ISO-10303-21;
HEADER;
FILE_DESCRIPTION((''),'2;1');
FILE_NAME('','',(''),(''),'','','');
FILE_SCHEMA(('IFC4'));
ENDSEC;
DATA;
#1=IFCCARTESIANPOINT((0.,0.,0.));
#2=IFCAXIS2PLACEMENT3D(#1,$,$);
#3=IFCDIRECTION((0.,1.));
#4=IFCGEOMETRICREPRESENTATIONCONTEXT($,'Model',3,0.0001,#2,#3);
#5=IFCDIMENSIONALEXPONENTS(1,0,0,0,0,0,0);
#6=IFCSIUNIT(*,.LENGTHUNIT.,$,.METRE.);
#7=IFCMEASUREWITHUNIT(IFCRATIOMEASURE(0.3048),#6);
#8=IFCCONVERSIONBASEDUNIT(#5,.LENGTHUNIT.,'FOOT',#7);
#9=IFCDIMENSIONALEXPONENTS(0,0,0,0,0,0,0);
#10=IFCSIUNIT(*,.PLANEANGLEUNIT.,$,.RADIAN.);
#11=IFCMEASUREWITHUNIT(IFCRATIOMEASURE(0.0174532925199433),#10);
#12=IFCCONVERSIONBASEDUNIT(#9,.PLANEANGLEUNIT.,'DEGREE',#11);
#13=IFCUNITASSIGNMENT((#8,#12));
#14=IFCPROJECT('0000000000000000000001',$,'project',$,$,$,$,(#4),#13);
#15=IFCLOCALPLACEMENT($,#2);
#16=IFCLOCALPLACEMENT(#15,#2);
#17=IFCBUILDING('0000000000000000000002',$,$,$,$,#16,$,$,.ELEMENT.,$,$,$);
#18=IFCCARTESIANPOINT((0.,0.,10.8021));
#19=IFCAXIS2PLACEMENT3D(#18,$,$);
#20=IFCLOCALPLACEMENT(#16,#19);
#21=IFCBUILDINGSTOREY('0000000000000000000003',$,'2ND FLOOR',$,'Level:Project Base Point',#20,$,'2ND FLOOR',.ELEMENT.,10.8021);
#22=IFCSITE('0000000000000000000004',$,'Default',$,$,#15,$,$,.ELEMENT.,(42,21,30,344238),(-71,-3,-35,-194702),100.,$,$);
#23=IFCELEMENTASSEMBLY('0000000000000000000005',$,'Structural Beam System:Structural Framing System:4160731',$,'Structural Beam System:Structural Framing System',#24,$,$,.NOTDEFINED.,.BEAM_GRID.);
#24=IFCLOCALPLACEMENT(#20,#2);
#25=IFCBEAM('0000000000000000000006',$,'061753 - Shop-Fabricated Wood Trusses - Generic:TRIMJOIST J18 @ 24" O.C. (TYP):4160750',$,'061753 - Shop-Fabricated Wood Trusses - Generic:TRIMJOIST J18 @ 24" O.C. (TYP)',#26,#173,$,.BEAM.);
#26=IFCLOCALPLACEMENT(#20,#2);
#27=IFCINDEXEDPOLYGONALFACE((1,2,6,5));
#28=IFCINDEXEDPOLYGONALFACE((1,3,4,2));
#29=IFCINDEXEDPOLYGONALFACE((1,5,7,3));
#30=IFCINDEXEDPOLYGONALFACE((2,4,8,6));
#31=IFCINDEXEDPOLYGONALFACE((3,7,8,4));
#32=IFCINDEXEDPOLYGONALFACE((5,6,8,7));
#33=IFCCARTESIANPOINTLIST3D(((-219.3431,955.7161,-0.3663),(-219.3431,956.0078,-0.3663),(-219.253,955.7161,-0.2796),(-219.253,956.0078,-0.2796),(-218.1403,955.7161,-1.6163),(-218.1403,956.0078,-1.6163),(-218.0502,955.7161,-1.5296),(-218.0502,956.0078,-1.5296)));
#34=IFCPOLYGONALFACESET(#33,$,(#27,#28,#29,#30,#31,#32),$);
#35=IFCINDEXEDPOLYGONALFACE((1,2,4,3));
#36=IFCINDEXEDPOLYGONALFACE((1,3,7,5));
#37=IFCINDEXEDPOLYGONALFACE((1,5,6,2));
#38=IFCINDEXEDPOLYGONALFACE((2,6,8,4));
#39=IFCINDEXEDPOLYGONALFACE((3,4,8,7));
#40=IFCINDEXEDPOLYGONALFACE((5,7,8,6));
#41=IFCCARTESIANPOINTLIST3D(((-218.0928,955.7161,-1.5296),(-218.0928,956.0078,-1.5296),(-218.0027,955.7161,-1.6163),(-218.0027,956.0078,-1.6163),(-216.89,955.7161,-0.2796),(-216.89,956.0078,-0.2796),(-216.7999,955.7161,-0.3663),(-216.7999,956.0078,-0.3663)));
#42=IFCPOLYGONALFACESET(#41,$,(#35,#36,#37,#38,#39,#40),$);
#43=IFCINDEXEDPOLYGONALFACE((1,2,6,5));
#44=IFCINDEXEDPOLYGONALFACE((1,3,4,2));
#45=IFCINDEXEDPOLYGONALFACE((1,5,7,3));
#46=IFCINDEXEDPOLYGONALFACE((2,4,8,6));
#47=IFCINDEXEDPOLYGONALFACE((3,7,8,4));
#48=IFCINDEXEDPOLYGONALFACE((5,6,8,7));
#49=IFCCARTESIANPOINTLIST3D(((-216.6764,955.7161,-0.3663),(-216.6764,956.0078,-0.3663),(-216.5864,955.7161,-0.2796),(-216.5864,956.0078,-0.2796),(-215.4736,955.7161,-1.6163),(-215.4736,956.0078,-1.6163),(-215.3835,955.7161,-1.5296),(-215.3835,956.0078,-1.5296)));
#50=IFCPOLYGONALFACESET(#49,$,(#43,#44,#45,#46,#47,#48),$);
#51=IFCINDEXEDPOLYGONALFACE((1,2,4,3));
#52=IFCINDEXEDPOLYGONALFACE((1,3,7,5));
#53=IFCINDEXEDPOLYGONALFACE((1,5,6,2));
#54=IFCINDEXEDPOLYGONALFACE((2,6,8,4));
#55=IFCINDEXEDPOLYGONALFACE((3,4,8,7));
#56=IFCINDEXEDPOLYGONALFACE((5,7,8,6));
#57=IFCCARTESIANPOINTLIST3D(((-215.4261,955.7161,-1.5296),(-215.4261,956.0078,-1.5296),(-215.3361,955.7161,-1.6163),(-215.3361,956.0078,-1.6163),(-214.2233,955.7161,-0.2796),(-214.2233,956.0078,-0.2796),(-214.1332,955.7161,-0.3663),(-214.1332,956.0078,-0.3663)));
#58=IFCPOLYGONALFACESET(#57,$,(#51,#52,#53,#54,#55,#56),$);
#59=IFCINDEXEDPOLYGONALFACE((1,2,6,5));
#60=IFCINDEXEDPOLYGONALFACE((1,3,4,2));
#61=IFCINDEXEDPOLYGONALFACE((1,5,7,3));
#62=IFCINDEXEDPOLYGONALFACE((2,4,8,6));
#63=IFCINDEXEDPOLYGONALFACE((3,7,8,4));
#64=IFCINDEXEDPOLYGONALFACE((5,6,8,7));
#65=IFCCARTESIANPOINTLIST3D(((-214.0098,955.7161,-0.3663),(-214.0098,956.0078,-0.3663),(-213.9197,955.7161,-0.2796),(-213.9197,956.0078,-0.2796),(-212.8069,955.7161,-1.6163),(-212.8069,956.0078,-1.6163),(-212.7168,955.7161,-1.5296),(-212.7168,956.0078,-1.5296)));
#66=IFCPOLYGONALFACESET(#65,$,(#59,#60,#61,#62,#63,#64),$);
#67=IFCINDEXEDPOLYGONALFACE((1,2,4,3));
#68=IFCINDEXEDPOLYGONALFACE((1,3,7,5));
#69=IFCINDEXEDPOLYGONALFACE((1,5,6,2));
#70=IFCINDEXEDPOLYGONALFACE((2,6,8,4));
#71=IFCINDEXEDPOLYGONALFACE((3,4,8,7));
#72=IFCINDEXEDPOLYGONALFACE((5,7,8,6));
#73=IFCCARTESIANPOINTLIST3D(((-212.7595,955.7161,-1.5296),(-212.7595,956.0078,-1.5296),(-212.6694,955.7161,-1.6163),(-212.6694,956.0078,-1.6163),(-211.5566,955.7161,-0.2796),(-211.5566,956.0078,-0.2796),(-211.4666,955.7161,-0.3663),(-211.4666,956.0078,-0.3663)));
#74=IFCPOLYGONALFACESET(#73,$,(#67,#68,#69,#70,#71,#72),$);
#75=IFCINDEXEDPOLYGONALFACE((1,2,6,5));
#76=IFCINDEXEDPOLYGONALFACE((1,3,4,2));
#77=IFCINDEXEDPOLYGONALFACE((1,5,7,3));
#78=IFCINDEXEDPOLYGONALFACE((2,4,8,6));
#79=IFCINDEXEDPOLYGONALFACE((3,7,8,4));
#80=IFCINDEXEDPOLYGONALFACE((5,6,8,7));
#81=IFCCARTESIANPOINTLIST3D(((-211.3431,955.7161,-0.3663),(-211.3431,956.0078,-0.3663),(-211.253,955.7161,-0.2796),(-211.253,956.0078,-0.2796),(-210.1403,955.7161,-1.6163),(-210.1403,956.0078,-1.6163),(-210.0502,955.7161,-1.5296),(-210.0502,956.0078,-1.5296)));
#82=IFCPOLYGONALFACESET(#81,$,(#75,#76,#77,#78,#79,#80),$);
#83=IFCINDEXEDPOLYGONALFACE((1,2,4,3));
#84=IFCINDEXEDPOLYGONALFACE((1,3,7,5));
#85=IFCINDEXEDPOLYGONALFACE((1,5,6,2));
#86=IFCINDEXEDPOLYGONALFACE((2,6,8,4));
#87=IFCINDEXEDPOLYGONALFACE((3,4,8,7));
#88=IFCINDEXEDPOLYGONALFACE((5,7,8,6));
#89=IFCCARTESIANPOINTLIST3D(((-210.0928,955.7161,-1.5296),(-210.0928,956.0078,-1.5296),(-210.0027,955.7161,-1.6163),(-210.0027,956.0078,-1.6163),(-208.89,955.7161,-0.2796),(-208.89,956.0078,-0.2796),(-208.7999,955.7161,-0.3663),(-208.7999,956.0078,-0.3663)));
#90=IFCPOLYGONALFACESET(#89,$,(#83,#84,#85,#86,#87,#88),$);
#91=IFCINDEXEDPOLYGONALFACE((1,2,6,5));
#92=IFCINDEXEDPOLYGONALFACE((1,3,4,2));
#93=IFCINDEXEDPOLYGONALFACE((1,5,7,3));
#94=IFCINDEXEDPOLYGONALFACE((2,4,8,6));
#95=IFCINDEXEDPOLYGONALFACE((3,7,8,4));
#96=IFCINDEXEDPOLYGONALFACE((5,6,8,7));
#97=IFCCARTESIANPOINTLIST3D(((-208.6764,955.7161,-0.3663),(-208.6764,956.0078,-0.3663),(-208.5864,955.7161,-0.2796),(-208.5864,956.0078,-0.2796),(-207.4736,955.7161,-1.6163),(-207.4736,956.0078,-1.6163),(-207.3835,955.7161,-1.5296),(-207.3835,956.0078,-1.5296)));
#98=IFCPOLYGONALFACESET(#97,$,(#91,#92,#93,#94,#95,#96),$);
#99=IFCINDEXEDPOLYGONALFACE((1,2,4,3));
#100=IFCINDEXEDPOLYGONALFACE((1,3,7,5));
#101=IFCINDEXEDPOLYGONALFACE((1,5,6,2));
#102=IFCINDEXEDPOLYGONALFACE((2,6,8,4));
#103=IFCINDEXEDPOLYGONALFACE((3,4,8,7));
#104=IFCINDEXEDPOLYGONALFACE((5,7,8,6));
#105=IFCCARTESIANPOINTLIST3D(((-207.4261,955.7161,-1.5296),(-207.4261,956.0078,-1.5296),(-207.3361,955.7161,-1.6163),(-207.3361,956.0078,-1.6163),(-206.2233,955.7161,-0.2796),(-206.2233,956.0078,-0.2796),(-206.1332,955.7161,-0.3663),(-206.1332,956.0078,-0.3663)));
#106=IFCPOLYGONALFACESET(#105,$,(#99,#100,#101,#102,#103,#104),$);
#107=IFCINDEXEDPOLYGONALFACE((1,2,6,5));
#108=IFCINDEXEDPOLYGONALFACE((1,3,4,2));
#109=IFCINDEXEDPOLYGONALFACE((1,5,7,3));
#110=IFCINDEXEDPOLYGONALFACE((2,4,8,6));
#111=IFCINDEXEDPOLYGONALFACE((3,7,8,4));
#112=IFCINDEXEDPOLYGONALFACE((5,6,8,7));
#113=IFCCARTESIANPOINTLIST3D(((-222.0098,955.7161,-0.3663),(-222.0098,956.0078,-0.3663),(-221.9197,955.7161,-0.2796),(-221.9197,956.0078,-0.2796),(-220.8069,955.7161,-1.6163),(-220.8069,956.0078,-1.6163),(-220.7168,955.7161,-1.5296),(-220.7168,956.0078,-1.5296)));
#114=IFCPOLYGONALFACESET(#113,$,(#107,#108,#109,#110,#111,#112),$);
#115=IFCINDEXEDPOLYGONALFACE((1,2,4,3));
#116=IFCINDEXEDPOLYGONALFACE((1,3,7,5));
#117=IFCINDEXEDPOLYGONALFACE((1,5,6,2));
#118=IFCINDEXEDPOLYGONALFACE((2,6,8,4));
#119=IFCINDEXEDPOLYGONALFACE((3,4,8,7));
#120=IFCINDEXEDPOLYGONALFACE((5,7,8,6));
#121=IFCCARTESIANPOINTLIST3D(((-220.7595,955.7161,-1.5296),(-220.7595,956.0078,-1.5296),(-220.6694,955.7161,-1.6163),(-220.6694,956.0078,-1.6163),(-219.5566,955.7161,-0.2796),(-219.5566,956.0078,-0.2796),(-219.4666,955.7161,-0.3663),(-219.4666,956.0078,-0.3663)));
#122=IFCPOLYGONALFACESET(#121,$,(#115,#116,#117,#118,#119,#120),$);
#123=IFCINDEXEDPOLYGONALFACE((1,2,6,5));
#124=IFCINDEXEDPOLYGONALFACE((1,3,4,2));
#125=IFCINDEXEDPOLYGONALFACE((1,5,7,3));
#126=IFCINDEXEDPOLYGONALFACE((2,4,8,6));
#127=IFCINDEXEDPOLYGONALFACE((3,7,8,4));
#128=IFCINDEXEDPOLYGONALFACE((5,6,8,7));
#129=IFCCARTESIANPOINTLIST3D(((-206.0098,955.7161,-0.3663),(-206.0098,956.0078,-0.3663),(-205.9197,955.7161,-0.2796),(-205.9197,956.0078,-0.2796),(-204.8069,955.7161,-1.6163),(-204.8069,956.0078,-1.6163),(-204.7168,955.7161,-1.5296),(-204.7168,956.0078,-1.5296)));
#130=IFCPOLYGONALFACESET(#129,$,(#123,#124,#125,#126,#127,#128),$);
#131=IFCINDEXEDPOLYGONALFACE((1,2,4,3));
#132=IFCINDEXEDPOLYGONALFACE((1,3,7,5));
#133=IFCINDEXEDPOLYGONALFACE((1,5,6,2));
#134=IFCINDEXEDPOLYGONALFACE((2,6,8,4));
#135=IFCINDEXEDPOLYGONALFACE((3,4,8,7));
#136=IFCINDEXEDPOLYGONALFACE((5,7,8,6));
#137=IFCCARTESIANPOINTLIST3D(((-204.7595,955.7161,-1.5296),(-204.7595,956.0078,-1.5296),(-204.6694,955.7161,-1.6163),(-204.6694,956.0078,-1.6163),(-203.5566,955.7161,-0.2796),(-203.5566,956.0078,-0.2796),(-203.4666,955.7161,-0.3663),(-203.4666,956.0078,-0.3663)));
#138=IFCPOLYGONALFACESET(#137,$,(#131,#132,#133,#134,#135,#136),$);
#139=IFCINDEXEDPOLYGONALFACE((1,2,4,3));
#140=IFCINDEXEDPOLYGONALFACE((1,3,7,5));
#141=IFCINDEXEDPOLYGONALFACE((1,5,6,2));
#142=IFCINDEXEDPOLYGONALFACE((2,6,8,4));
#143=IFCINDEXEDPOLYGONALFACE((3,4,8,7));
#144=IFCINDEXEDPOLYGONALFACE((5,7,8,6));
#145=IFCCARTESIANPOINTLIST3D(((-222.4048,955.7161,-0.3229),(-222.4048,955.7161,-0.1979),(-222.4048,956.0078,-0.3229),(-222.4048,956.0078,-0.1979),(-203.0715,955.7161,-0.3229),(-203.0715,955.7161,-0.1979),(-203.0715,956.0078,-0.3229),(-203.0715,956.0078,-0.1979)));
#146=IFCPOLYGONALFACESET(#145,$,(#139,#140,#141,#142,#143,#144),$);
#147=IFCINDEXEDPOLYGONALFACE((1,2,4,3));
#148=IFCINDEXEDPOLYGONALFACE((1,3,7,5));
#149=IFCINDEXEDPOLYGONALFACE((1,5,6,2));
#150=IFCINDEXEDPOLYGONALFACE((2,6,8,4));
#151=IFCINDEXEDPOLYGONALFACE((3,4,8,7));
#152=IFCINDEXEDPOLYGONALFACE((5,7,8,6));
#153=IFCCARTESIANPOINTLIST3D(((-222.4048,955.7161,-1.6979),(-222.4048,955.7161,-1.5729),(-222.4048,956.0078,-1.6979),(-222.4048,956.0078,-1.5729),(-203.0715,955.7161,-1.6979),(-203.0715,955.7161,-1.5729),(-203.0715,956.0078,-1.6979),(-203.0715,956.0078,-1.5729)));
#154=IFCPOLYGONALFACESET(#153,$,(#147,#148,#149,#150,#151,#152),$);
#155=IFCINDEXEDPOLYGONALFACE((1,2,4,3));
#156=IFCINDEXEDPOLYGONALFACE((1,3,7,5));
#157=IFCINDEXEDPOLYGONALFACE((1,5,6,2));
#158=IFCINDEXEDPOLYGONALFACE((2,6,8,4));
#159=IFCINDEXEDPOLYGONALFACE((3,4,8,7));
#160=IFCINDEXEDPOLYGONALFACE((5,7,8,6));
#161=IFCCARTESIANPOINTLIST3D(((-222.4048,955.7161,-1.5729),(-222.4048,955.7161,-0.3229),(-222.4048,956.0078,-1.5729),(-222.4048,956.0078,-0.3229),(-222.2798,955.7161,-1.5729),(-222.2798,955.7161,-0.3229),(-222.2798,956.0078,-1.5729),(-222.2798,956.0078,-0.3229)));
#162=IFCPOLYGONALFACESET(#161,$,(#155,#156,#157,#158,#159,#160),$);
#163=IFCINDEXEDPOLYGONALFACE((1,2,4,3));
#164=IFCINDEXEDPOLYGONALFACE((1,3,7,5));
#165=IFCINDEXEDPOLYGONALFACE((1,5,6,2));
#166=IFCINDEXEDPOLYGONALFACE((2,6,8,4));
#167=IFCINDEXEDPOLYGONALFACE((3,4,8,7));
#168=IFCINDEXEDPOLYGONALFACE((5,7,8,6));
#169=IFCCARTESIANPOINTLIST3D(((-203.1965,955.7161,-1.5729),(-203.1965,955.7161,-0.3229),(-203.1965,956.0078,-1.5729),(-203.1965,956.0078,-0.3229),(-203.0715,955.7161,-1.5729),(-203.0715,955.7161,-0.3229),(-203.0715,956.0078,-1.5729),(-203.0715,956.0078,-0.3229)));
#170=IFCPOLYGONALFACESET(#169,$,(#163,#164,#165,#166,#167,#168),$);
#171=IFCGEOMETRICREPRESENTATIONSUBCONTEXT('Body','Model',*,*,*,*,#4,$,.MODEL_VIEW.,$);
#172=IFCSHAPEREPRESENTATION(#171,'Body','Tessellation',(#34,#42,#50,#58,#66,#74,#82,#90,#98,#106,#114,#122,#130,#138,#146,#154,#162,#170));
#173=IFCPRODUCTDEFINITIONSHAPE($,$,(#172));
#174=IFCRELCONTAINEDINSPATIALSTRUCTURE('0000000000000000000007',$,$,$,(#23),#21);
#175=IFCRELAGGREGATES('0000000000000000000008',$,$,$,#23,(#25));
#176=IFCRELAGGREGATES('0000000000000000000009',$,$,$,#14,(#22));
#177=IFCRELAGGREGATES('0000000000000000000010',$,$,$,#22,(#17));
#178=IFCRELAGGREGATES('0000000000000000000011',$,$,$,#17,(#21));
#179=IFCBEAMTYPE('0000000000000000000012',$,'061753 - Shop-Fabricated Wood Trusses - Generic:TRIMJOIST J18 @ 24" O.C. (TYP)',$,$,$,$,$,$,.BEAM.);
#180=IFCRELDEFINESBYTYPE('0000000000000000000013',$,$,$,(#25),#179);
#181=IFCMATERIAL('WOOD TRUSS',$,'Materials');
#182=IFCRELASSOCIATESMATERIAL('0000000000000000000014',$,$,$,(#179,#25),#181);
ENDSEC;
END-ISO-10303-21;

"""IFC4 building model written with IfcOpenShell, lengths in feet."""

from ifc_helpers import new_model, entity, si_unit, converted_unit, direction, frame, frame_2d, origin, origin_2d_with_axis, place, context, subcontext, project, spatial, rectangle, extrude, source, transform, mapped, material, material_profile, profile_set, profile_usage, type_object, type_shapes, element, aggregate, save


model = new_model("IFC4")

# Units and contexts
model_context = context("Model", 3, precision=0.0001, world=origin(), true_north=direction((0.0, 1.0)))
body_context = subcontext(model_context, "Body", "Model", "MODEL_VIEW")
ifc_project = project(units=[converted_unit("LENGTHUNIT", "FOOT", entity("IfcRatioMeasure", 0.3048), si_unit("LENGTHUNIT", "METRE"), dimensions=[1, 0, 0, 0, 0, 0, 0]), converted_unit("PLANEANGLEUNIT", "DEGREE", entity("IfcRatioMeasure", 0.0174532925199433), si_unit("PLANEANGLEUNIT", "RADIAN"), dimensions=[0, 0, 0, 0, 0, 0, 0])], contexts=[model_context])

# Site, building, storey
site_placement = place(None, origin())
site = spatial("IfcSite", under=ifc_project, at=site_placement, Name="Default", CompositionType="ELEMENT", RefLatitude=(42, 21, 30, 344238), RefLongitude=(-71, -3, -35, -194702), RefElevation=100.0)
building_placement = place(site_placement, origin())
building = spatial("IfcBuilding", under=site, at=building_placement, CompositionType="ELEMENT")
storey_placement = place(building_placement, frame((0.0, 0.0, 10.8021)))
storey = spatial("IfcBuildingStorey", under=building, at=storey_placement, Name="2ND FLOOR", ObjectType="Level:Project Base Point", LongName="2ND FLOOR", CompositionType="ELEMENT", Elevation=10.8021)

# Shared definitions
ifc_material_1 = material(Name="WOOD TRUSS", Category="Materials")
ifc_material_profile_1 = material_profile(ifc_material_1, rectangle(XDim=1.7347, YDim=0.125, at=frame_2d((0.0, 0.0), x_axis=(1.0, 0.0))), Name="TRIMJOIST J18 @ 24\" O.C. (TYP)")
ifc_material_profile_2 = material_profile(ifc_material_1, rectangle(XDim=1.7347, YDim=0.125, at=frame_2d((0.0, 0.0), x_axis=(1.0, 0.0))), Name="TRIMJOIST J18 @ 24\" O.C. (TYP)")
ifc_material_profile_3 = material_profile(ifc_material_1, rectangle(XDim=1.7347, YDim=0.125, at=frame_2d((0.0, 0.0), x_axis=(1.0, 0.0))), Name="TRIMJOIST J18 @ 24\" O.C. (TYP)")
ifc_material_profile_4 = material_profile(ifc_material_1, rectangle(XDim=1.7347, YDim=0.125, at=frame_2d((0.0, 0.0), x_axis=(1.0, 0.0))), Name="TRIMJOIST J18 @ 24\" O.C. (TYP)")
ifc_material_profile_5 = material_profile(ifc_material_1, rectangle(XDim=1.7347, YDim=0.125, at=frame_2d((0.0, 0.0), x_axis=(1.0, 0.0))), Name="TRIMJOIST J18 @ 24\" O.C. (TYP)")
ifc_material_profile_6 = material_profile(ifc_material_1, rectangle(XDim=1.7347, YDim=0.125, at=frame_2d((0.0, 0.0), x_axis=(1.0, 0.0))), Name="TRIMJOIST J18 @ 24\" O.C. (TYP)")
ifc_material_profile_7 = material_profile(ifc_material_1, rectangle(XDim=1.7347, YDim=0.125, at=frame_2d((0.0, 0.0), x_axis=(1.0, 0.0))), Name="TRIMJOIST J18 @ 24\" O.C. (TYP)")
ifc_material_profile_8 = material_profile(ifc_material_1, rectangle(XDim=1.7347, YDim=0.125, at=frame_2d((0.0, 0.0), x_axis=(1.0, 0.0))), Name="TRIMJOIST J18 @ 24\" O.C. (TYP)")
ifc_material_profile_9 = material_profile(ifc_material_1, rectangle(XDim=1.7347, YDim=0.125, at=frame_2d((0.0, 0.0), x_axis=(1.0, 0.0))), Name="TRIMJOIST J18 @ 24\" O.C. (TYP)")
ifc_material_profile_10 = material_profile(ifc_material_1, rectangle(XDim=1.7347, YDim=0.125, at=origin_2d_with_axis()), Name="TRIMJOIST J18 @ 24\" O.C. (TYP)")
ifc_material_profile_11 = material_profile(ifc_material_1, rectangle(XDim=0.125, YDim=0.2917, at=origin_2d_with_axis()), Name="TRIMJOIST J18 @ 24\" O.C. (TYP)")
ifc_material_profile_12 = material_profile(ifc_material_1, rectangle(XDim=0.125, YDim=0.2917, at=origin_2d_with_axis()), Name="TRIMJOIST J18 @ 24\" O.C. (TYP)")
ifc_material_profile_13 = material_profile(ifc_material_1, rectangle(XDim=1.25, YDim=0.2917, at=origin_2d_with_axis()), Name="TRIMJOIST J18 @ 24\" O.C. (TYP)")
ifc_material_profile_14 = material_profile(ifc_material_1, rectangle(XDim=1.25, YDim=0.2917, at=origin_2d_with_axis()), Name="TRIMJOIST J18 @ 24\" O.C. (TYP)")
ifc_profile_set_1 = profile_set([ifc_material_profile_1, ifc_material_profile_2, ifc_material_profile_3, ifc_material_profile_4, ifc_material_profile_5, ifc_material_profile_6, ifc_material_profile_7, ifc_material_profile_8, ifc_material_profile_9, ifc_material_profile_10, ifc_material_profile_11, ifc_material_profile_12, ifc_material_profile_13, ifc_material_profile_14], Name="TRIMJOIST J18 @ 24\" O.C. (TYP)")
beam_type_1 = type_object("IfcBeamType", Name="061753 - Shop-Fabricated Wood Trusses - Generic:TRIMJOIST J18 @ 24\" O.C. (TYP)", PredefinedType="BEAM", material=ifc_profile_set_1)
shared_shape_1 = source(origin(), body_context, "Body", "SweptSolid", [
    extrude(rectangle(XDim=1.7347, YDim=0.125, at=frame_2d((0.0, 0.0), x_axis=(1.0, 0.0))), frame((5.9585, -0.1458, 0.0), z_axis=(0.0, 1.0, 0.0), x_axis=(0.693383, 0.0, 0.720569)), (0.0, 0.0, 1.0), 0.2917),
    extrude(rectangle(XDim=1.7347, YDim=0.125, at=origin_2d_with_axis()), frame((4.7082, -0.1458, 0.0), z_axis=(0.0, 1.0, 0.0), x_axis=(0.693383, 0.0, -0.720569)), (0.0, 0.0, 1.0), 0.2917),
    extrude(rectangle(XDim=1.7347, YDim=0.125, at=frame_2d((0.0, 0.0), x_axis=(1.0, 0.0))), frame((3.2918, -0.1458, 0.0), z_axis=(0.0, 1.0, 0.0), x_axis=(0.693383, 0.0, 0.720569)), (0.0, 0.0, 1.0), 0.2917),
    extrude(rectangle(XDim=1.7347, YDim=0.125, at=frame_2d((0.0, 0.0), x_axis=(1.0, 0.0))), frame((2.0415, -0.1458, 0.0), z_axis=(0.0, 1.0, 0.0), x_axis=(0.693383, 0.0, -0.720569)), (0.0, 0.0, 1.0), 0.2917),
    extrude(rectangle(XDim=1.7347, YDim=0.125, at=frame_2d((0.0, 0.0), x_axis=(1.0, 0.0))), frame((0.6251, -0.1458, 0.0), z_axis=(0.0, 1.0, 0.0), x_axis=(0.693383, 0.0, 0.720569)), (0.0, 0.0, 1.0), 0.2917),
    extrude(rectangle(XDim=1.7347, YDim=0.125, at=frame_2d((0.0, 0.0), x_axis=(1.0, 0.0))), frame((-0.6251, -0.1458, 0.0), z_axis=(0.0, 1.0, 0.0), x_axis=(0.693383, 0.0, -0.720569)), (0.0, 0.0, 1.0), 0.2917),
    extrude(rectangle(XDim=1.7347, YDim=0.125, at=frame_2d((0.0, 0.0), x_axis=(1.0, 0.0))), frame((-2.0415, -0.1458, 0.0), z_axis=(0.0, 1.0, 0.0), x_axis=(0.693383, 0.0, 0.720569)), (0.0, 0.0, 1.0), 0.2917),
    extrude(rectangle(XDim=1.7347, YDim=0.125, at=origin_2d_with_axis()), frame((-3.2918, -0.1458, 0.0), z_axis=(0.0, 1.0, 0.0), x_axis=(0.693383, 0.0, -0.720569)), (0.0, 0.0, 1.0), 0.2917),
    extrude(rectangle(XDim=1.7347, YDim=0.125, at=frame_2d((0.0, 0.0), x_axis=(1.0, 0.0))), frame((-4.7082, -0.1458, 0.0), z_axis=(0.0, 1.0, 0.0), x_axis=(0.693383, 0.0, 0.720569)), (0.0, 0.0, 1.0), 0.2917),
    extrude(rectangle(XDim=1.7347, YDim=0.125, at=frame_2d((0.0, 0.0), x_axis=(1.0, 0.0))), frame((-5.9585, -0.1458, 0.0), z_axis=(0.0, 1.0, 0.0), x_axis=(0.693383, 0.0, -0.720569)), (0.0, 0.0, 1.0), 0.2917),
    extrude(rectangle(XDim=1.7347, YDim=0.125, at=frame_2d((0.0, 0.0), x_axis=(1.0, 0.0))), frame((8.6251, -0.1458, 0.0), z_axis=(0.0, 1.0, 0.0), x_axis=(0.693383, 0.0, 0.720569)), (0.0, 0.0, 1.0), 0.2917),
    extrude(rectangle(XDim=1.7347, YDim=0.125, at=origin_2d_with_axis()), frame((7.3749, -0.1458, 0.0), z_axis=(0.0, 1.0, 0.0), x_axis=(0.693383, 0.0, -0.720569)), (0.0, 0.0, 1.0), 0.2917),
    extrude(rectangle(XDim=1.7347, YDim=0.125, at=frame_2d((0.0, 0.0), x_axis=(1.0, 0.0))), frame((-7.3749, -0.1458, 0.0), z_axis=(0.0, 1.0, 0.0), x_axis=(0.693383, 0.0, 0.720569)), (0.0, 0.0, 1.0), 0.2917),
    extrude(rectangle(XDim=1.7347, YDim=0.125, at=origin_2d_with_axis()), frame((-8.6251, -0.1458, 0.0), z_axis=(0.0, 1.0, 0.0), x_axis=(0.693383, 0.0, -0.720569)), (0.0, 0.0, 1.0), 0.2917),
    extrude(rectangle(XDim=0.125, YDim=0.2917, at=origin_2d_with_axis()), frame((-9.6667, 0.0, 0.6875), z_axis=(1.0, 0.0, 0.0), x_axis=(0.0, 0.0, -1.0)), (0.0, 0.0, 1.0), 19.3333),
    extrude(rectangle(XDim=0.125, YDim=0.2917, at=origin_2d_with_axis()), frame((-9.6667, 0.0, -0.6875), z_axis=(1.0, 0.0, 0.0), x_axis=(0.0, 0.0, -1.0)), (0.0, 0.0, 1.0), 19.3333),
    extrude(rectangle(XDim=1.25, YDim=0.2917, at=origin_2d_with_axis()), frame((9.5417, 0.0, 0.0), z_axis=(1.0, 0.0, 0.0), x_axis=(0.0, 0.0, -1.0)), (0.0, 0.0, 1.0), 0.125),
    extrude(rectangle(XDim=1.25, YDim=0.2917, at=origin_2d_with_axis()), frame((-9.6667, 0.0, 0.0), z_axis=(1.0, 0.0, 0.0), x_axis=(0.0, 0.0, -1.0)), (0.0, 0.0, 1.0), 0.125),
])
type_shapes(beam_type_1, [shared_shape_1])

# Element assembly, beam
assembly_1_placement = place(storey_placement, origin())
assembly_1 = element("IfcElementAssembly", 1, at=assembly_1_placement, inside=storey, Name="Structural Beam System:Structural Framing System:4160731", ObjectType="Structural Beam System:Structural Framing System", AssemblyPlace="NOTDEFINED", PredefinedType="BEAM_GRID")
ifc_profile_usage_1 = profile_usage(ifc_profile_set_1, cardinal=8)
beam_1_placement = place(assembly_1_placement, frame((-212.7382, 955.8619, -0.9479), z_axis=(0.0, 0.0, 1.0), x_axis=(-1.0, 0.0, 0.0)))
beam_1 = element("IfcBeam", 2, at=beam_1_placement, type_object=beam_type_1, material=ifc_profile_usage_1, Name="061753 - Shop-Fabricated Wood Trusses - Generic:TRIMJOIST J18 @ 24\" O.C. (TYP):4160750", ObjectType="061753 - Shop-Fabricated Wood Trusses - Generic:TRIMJOIST J18 @ 24\" O.C. (TYP)", PredefinedType="BEAM", context=body_context, shape_type="MappedRepresentation", body=[
    mapped(shared_shape_1, transform((0.0, 0.0, 0.0), scale=1.0)),
])

aggregate(assembly_1, [beam_1])

save(model, "model.ifc")
